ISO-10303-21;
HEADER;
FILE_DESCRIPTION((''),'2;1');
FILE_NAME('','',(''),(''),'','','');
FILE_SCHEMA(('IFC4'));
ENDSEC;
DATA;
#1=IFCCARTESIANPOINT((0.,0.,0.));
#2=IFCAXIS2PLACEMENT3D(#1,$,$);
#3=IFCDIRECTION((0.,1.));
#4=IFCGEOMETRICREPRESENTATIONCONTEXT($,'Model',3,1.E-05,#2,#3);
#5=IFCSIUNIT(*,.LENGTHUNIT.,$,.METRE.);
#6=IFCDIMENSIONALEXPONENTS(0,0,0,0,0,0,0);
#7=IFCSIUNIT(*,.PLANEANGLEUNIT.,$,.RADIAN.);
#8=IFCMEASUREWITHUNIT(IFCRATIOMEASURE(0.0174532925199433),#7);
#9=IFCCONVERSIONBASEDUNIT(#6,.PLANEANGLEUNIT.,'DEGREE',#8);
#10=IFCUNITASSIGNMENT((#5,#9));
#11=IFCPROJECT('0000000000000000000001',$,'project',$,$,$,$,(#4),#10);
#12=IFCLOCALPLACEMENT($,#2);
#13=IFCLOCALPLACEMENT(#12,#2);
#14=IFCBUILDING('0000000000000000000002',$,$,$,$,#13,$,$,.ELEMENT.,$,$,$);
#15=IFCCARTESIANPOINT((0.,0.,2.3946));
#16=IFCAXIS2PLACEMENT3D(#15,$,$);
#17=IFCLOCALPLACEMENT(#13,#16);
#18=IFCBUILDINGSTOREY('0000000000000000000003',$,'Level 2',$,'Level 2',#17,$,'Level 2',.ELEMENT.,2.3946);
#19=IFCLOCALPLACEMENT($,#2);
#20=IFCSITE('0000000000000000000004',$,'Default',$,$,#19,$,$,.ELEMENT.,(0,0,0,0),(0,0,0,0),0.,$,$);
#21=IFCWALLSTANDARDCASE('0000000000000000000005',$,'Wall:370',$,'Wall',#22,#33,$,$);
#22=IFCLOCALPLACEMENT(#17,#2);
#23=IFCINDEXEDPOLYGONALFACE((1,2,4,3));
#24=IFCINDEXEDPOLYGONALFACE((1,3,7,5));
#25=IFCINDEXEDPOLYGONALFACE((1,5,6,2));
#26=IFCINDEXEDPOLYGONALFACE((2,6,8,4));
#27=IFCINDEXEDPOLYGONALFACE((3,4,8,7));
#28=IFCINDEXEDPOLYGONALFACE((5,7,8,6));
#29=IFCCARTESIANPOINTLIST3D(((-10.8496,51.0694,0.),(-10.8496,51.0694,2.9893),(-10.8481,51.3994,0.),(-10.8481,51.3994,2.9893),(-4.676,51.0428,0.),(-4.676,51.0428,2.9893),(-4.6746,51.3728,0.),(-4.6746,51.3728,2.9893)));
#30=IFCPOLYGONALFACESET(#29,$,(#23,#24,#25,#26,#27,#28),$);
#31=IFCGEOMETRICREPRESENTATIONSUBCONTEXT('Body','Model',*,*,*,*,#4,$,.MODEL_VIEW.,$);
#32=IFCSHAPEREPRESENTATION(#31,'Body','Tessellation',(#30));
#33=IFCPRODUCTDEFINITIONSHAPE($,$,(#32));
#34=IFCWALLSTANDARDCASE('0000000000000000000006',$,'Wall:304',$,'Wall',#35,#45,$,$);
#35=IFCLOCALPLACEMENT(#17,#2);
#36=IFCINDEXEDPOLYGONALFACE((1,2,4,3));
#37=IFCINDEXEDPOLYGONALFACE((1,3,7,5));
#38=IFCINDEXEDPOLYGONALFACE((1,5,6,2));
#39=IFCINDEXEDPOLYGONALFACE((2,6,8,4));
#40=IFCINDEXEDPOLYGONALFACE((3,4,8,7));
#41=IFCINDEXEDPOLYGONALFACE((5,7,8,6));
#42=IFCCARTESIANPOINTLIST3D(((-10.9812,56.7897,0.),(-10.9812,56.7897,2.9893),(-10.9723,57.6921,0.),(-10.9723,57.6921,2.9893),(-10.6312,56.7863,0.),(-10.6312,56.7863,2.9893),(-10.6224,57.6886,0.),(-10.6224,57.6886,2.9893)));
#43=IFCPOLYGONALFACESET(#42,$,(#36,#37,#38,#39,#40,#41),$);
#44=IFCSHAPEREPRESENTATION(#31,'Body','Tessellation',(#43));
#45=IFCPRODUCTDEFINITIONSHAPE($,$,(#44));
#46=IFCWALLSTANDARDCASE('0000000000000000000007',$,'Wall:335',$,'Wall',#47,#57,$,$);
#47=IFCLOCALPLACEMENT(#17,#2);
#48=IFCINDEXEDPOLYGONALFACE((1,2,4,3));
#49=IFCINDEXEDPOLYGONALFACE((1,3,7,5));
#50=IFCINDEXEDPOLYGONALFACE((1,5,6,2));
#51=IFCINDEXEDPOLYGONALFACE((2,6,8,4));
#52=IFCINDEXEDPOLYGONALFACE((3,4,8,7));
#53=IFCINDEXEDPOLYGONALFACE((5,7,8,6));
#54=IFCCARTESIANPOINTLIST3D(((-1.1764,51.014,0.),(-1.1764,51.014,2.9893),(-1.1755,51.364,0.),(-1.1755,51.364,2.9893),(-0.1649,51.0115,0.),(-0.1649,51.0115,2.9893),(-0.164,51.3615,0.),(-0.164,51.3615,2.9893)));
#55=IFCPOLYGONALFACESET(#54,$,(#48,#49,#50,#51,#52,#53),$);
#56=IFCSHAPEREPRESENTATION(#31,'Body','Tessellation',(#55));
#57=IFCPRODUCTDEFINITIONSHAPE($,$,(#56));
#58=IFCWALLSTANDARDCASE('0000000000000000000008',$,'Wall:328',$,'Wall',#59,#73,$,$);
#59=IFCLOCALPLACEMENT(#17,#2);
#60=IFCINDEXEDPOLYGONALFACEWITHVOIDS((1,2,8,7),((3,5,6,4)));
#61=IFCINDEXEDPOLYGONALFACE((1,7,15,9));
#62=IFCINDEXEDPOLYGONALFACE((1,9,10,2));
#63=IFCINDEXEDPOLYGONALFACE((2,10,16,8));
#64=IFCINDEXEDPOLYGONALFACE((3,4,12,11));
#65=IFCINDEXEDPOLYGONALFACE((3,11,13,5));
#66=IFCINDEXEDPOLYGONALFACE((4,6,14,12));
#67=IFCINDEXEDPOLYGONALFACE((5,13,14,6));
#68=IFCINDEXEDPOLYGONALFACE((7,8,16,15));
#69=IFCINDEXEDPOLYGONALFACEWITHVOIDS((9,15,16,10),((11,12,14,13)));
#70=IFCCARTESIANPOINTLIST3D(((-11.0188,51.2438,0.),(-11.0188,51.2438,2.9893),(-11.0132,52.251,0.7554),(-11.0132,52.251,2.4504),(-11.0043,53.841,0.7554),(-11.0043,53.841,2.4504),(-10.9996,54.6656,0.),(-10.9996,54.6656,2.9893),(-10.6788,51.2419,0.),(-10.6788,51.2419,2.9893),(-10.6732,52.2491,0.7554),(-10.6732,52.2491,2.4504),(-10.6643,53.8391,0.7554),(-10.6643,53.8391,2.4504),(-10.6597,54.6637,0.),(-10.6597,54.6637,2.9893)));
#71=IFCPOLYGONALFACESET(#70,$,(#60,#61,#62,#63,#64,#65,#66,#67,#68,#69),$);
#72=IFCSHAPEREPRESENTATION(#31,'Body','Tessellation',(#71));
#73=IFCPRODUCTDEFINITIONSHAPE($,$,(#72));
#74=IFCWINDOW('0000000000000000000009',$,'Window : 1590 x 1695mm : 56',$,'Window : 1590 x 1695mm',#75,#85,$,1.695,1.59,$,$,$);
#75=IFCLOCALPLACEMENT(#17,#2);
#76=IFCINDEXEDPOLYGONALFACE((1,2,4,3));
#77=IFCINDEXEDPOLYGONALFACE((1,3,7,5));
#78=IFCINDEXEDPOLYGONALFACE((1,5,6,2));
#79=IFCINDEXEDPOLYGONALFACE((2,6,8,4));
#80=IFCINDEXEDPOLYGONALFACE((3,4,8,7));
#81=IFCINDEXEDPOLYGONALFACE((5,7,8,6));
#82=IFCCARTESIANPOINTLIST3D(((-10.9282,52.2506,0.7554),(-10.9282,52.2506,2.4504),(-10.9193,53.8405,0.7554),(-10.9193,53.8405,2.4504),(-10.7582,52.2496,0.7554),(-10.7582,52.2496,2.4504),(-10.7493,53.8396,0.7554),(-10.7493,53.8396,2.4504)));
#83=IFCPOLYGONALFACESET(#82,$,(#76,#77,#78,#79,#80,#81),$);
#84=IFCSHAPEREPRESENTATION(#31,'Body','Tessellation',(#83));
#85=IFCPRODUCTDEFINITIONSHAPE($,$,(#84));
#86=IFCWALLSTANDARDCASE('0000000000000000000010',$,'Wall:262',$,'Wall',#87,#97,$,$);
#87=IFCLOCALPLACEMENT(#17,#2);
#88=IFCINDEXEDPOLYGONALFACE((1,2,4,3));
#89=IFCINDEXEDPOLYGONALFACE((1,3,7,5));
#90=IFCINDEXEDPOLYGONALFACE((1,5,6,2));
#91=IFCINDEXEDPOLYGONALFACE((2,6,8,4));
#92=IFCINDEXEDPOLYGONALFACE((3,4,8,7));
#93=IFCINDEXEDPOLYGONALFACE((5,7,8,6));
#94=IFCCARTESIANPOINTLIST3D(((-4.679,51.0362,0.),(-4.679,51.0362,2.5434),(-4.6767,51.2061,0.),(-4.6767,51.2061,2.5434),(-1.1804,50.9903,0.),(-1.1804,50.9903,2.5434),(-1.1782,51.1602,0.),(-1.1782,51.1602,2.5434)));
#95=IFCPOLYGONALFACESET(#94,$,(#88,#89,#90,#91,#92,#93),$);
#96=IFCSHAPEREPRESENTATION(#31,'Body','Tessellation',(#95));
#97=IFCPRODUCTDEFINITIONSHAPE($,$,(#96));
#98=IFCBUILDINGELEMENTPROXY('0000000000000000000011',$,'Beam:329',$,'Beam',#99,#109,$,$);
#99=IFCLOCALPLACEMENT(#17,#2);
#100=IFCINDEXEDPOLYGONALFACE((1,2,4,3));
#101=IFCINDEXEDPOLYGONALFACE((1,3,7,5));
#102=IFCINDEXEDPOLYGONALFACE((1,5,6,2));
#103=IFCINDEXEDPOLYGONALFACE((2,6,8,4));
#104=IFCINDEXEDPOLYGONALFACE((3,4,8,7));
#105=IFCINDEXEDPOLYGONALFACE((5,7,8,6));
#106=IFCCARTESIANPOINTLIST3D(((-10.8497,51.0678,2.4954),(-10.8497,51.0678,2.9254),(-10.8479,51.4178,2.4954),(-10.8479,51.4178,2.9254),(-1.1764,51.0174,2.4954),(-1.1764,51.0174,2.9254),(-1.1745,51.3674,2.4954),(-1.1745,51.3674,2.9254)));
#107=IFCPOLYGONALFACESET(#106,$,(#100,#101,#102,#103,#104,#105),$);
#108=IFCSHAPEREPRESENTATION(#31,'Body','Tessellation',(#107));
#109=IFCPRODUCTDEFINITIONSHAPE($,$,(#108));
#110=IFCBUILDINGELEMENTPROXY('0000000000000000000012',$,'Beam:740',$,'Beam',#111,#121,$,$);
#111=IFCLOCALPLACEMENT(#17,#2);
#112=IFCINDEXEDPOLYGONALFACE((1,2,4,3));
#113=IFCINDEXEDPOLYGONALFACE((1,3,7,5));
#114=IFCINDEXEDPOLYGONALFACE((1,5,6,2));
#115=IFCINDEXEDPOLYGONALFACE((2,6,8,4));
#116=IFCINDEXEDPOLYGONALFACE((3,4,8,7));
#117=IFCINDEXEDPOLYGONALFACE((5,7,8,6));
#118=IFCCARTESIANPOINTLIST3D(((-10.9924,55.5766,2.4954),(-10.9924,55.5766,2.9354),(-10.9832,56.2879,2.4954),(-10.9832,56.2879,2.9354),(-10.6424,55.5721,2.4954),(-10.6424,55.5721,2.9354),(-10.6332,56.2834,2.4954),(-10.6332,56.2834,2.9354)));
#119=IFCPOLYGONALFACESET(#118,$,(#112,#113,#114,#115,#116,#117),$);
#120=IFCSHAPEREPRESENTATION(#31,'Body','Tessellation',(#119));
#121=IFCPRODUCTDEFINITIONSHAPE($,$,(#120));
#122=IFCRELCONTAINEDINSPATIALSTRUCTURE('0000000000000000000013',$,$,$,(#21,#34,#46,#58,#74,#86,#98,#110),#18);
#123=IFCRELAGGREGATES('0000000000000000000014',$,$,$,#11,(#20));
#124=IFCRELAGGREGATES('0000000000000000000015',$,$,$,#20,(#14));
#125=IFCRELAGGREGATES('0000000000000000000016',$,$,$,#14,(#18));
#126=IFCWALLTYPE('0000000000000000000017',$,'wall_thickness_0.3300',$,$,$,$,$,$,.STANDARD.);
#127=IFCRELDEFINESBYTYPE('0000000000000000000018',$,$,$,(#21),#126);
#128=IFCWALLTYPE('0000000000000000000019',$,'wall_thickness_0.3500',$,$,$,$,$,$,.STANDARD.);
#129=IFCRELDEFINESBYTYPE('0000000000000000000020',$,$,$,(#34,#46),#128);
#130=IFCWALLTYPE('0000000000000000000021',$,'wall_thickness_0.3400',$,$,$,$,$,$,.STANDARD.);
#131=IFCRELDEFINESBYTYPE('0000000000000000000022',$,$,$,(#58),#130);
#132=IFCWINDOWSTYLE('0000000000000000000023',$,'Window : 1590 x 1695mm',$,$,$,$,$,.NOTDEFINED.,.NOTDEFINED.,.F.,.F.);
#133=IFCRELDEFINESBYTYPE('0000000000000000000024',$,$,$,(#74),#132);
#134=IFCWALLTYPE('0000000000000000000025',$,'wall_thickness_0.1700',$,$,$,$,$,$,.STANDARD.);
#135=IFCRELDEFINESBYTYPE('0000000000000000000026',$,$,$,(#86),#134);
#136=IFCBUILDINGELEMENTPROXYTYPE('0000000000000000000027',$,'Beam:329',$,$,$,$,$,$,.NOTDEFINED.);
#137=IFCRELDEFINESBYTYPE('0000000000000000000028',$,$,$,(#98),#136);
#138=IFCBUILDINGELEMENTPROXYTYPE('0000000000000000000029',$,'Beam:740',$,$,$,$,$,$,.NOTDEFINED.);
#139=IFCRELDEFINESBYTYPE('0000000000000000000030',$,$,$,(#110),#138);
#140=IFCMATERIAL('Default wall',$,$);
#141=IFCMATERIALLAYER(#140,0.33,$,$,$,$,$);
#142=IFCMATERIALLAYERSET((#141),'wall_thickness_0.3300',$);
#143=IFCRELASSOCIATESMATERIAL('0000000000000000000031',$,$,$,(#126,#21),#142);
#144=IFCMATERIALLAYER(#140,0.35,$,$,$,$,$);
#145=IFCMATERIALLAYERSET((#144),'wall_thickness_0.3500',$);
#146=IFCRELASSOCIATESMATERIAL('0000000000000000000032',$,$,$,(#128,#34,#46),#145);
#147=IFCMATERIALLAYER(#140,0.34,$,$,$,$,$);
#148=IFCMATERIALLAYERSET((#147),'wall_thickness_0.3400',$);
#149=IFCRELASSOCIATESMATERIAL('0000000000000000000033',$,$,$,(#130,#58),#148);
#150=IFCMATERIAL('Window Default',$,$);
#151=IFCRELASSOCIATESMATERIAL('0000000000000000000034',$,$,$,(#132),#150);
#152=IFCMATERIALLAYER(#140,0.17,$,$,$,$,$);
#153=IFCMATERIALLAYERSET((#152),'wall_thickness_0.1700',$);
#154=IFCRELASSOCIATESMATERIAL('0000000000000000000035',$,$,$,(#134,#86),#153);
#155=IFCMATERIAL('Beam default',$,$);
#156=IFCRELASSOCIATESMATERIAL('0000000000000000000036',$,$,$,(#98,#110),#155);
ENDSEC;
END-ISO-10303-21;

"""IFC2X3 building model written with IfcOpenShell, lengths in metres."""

from ifc_helpers import new_model, entity, si_unit, converted_unit, direction, frame, frame_2d, origin, origin_2d_with_axis, place, context, subcontext, project, spatial, polyline, rectangle, outline, extrude, source, transform, mapped, material, layer, layer_set, layer_usage, type_object, type_shapes, element, fill, save


model = new_model("IFC2X3")

# Units and contexts
model_context = context("Model", 3, precision=1e-05, world=origin(), true_north=direction((0.0, 1.0)))
body_context = subcontext(model_context, "Body", "Model", "MODEL_VIEW")
ifc_project = project(units=[si_unit("LENGTHUNIT", "METRE"), converted_unit("PLANEANGLEUNIT", "DEGREE", entity("IfcRatioMeasure", 0.0174532925199433), si_unit("PLANEANGLEUNIT", "RADIAN"), dimensions=[0, 0, 0, 0, 0, 0, 0])], contexts=[model_context])

# Site, building, storey
site_placement = place(None, origin())
site = spatial("IfcSite", under=ifc_project, at=site_placement, Name="Default", CompositionType="ELEMENT", RefLatitude=(0, 0, 0, 0), RefLongitude=(0, 0, 0, 0), RefElevation=0.0)
placement_1 = place(None, origin())
building_placement = place(placement_1, origin())
building = spatial("IfcBuilding", under=site, at=building_placement, CompositionType="ELEMENT")
storey_placement = place(building_placement, frame((0.0, 0.0, 2.3946)))
storey = spatial("IfcBuildingStorey", under=building, at=storey_placement, Name="Level 2", ObjectType="Level 2", LongName="Level 2", CompositionType="ELEMENT", Elevation=2.3946)

# Shared definitions
ifc_material_1 = material(Name="Default wall")

# Shared definitions
ifc_material_2 = material(Name="Window Default")

# Walls
ifc_layer_1 = layer(ifc_material_1, 0.33)
ifc_layer_set_1 = layer_set([ifc_layer_1], Name="wall_thickness_0.3300")
ifc_layer_usage_1 = layer_usage(ifc_layer_set_1, "AXIS2", "POSITIVE", -0.165)
wall_type_1 = type_object("IfcWallType", Name="wall_thickness_0.3300", PredefinedType="STANDARD", material=ifc_layer_set_1)
wall_1_placement = place(storey_placement, frame((-10.8489, 51.2344, 0.0), z_axis=(0.0, 0.0, 1.0), x_axis=(0.999991, -0.004316, 0.0)))
element("IfcWallStandardCase", 1, at=wall_1_placement, inside=storey, type_object=wall_type_1, material=ifc_layer_usage_1, Name="Wall:370", ObjectType="Wall", context=body_context, shape_type="SweptSolid", body=[
    extrude(outline(polyline([(6.1736, -0.165), (6.1736, 0.165), (0.0, 0.165), (0.0, -0.165), (6.1736, -0.165)])), origin(), (0.0, 0.0, 1.0), 2.9893),
])
ifc_layer_2 = layer(ifc_material_1, 0.35)
ifc_layer_set_2 = layer_set([ifc_layer_2], Name="wall_thickness_0.3500")
ifc_layer_usage_2 = layer_usage(ifc_layer_set_2, "AXIS2", "POSITIVE", -0.175)
wall_type_2 = type_object("IfcWallType", Name="wall_thickness_0.3500", PredefinedType="STANDARD", material=ifc_layer_set_2)
wall_2_placement = place(storey_placement, frame((-10.7973, 57.6904, 0.0), z_axis=(0.0, 0.0, 1.0), x_axis=(-0.009837, -0.999952, 0.0)))
element("IfcWallStandardCase", 2, at=wall_2_placement, inside=storey, type_object=wall_type_2, material=ifc_layer_usage_2, Name="Wall:304", ObjectType="Wall", context=body_context, shape_type="SweptSolid", body=[
    extrude(outline(polyline([(0.9024, -0.175), (0.9024, 0.175), (0.0, 0.175), (0.0, -0.175), (0.9024, -0.175)])), origin(), (0.0, 0.0, 1.0), 2.9893),
])
wall_3_placement = place(storey_placement, frame((-1.1759, 51.189, 0.0), z_axis=(0.0, 0.0, 1.0), x_axis=(0.999997, -0.002451, 0.0)))
element("IfcWallStandardCase", 3, at=wall_3_placement, inside=storey, type_object=wall_type_2, material=ifc_layer_usage_2, Name="Wall:335", ObjectType="Wall", context=body_context, shape_type="SweptSolid", body=[
    extrude(outline(polyline([(1.0115, -0.175), (1.0115, 0.175), (0.0, 0.175), (0.0, -0.175), (1.0115, -0.175)])), origin(), (0.0, 0.0, 1.0), 2.9893),
])

# Wall, opening, window
ifc_layer_3 = layer(ifc_material_1, 0.34)
ifc_layer_set_3 = layer_set([ifc_layer_3], Name="wall_thickness_0.3400")
ifc_layer_usage_3 = layer_usage(ifc_layer_set_3, "AXIS2", "POSITIVE", -0.17)
wall_type_3 = type_object("IfcWallType", Name="wall_thickness_0.3400", PredefinedType="STANDARD", material=ifc_layer_set_3)
wall_4_placement = place(storey_placement, frame((-10.8297, 54.6647, 0.0), z_axis=(0.0, 0.0, 1.0), x_axis=(-0.005599, -0.999984, 0.0)))
wall_4 = element("IfcWallStandardCase", 4, at=wall_4_placement, inside=storey, type_object=wall_type_3, material=ifc_layer_usage_3, Name="Wall:328", ObjectType="Wall", context=body_context, shape_type="SweptSolid", body=[
    extrude(outline(polyline([(3.4219, -0.17), (3.4219, 0.17), (0.0, 0.17), (0.0, -0.17), (3.4219, -0.17)])), origin(), (0.0, 0.0, 1.0), 2.9893),
])
opening_1_placement = place(wall_4_placement, frame((0.8246, -0.17, 0.7554)))
opening_1 = element("IfcOpeningElement", 5, at=opening_1_placement, cuts=wall_4, ObjectType="Opening", context=body_context, shape_type="SweptSolid", body=[
    extrude(rectangle(XDim=1.59, YDim=1.695, at=frame_2d((0.8475, 0.795), x_axis=(0.0, 1.0))), frame((0.0, 0.0, 0.0), z_axis=(0.0, 1.0, 0.0), x_axis=(0.0, 0.0, 1.0)), (0.0, 0.0, 1.0), 0.34),
])
window_style_1 = type_object("IfcWindowStyle", Name="Window : 1590 x 1695mm", ConstructionType="NOTDEFINED", OperationType="NOTDEFINED", ParameterTakesPrecedence=False, Sizeable=False, material=ifc_material_2)
shared_shape_1 = source(origin(), body_context, "Body", "SweptSolid", [
    extrude(rectangle(XDim=0.17, YDim=1.59, at=origin_2d_with_axis()), frame((0.795, 0.17, 0.0), z_axis=(0.0, 0.0, 1.0), x_axis=(0.0, 1.0, 0.0)), (0.0, 0.0, 1.0), 1.695),
])
type_shapes(window_style_1, [shared_shape_1])
window_1_placement = place(opening_1_placement, origin())
window_1 = element("IfcWindow", 6, at=window_1_placement, inside=storey, type_object=window_style_1, Name="Window : 1590 x 1695mm : 56", ObjectType="Window : 1590 x 1695mm", OverallHeight=1.695, OverallWidth=1.59, context=body_context, shape_type="MappedRepresentation", body=[
    mapped(shared_shape_1, transform((0.0, 0.0, 0.0), scale=1.0)),
])
fill(opening_1, window_1)

# Wall
ifc_layer_4 = layer(ifc_material_1, 0.17)
ifc_layer_set_4 = layer_set([ifc_layer_4], Name="wall_thickness_0.1700")
ifc_layer_usage_4 = layer_usage(ifc_layer_set_4, "AXIS2", "POSITIVE", -0.085)
wall_type_4 = type_object("IfcWallType", Name="wall_thickness_0.1700", PredefinedType="STANDARD", material=ifc_layer_set_4)
wall_5_placement = place(storey_placement, frame((-4.6779, 51.1211, 0.0), z_axis=(0.0, 0.0, 1.0), x_axis=(0.999914, -0.013116, 0.0)))
element("IfcWallStandardCase", 7, at=wall_5_placement, inside=storey, type_object=wall_type_4, material=ifc_layer_usage_4, Name="Wall:262", ObjectType="Wall", context=body_context, shape_type="SweptSolid", body=[
    extrude(outline(polyline([(3.4989, -0.085), (3.4989, 0.085), (0.0, 0.085), (0.0, -0.085), (3.4989, -0.085)])), origin(), (0.0, 0.0, 1.0), 2.5434),
])

# Building element proxies
ifc_material_3 = material(Name="Beam default")
building_element_proxy_type_1 = type_object("IfcBuildingElementProxyType", Name="Beam:329", PredefinedType="NOTDEFINED")
shared_shape_2 = source(origin(), body_context, "Body", "SweptSolid", [
    extrude(outline(polyline([(9.6735, -0.175), (9.6735, 0.175), (0.0, 0.175), (0.0, -0.175), (9.6735, -0.175)])), origin(), (0.0, 0.0, 1.0), 0.43),
])
type_shapes(building_element_proxy_type_1, [shared_shape_2])
placement_2 = place(building_placement, frame((0.0, 0.0, 4.89)))
proxy_1_placement = place(placement_2, frame((-10.8488, 51.2428, 0.0), z_axis=(0.0, 0.0, 1.0), x_axis=(0.999986, -0.005211, 0.0)))
element("IfcBuildingElementProxy", 8, at=proxy_1_placement, inside=storey, type_object=building_element_proxy_type_1, material=ifc_material_3, Name="Beam:329", ObjectType="Beam", context=body_context, shape_type="MappedRepresentation", body=[
    mapped(shared_shape_2, transform((0.0, 0.0, 0.0), scale=1.0)),
])
building_element_proxy_type_2 = type_object("IfcBuildingElementProxyType", Name="Beam:740", PredefinedType="NOTDEFINED")
shared_shape_3 = source(origin(), body_context, "Body", "SweptSolid", [
    extrude(outline(polyline([(0.7113, -0.175), (0.7113, 0.175), (0.0, 0.175), (0.0, -0.175), (0.7113, -0.175)])), origin(), (0.0, 0.0, 1.0), 0.44),
])
type_shapes(building_element_proxy_type_2, [shared_shape_3])
placement_3 = place(building_placement, frame((0.0, 0.0, 4.89)))
proxy_2_placement = place(placement_3, frame((-10.8082, 56.2856, 0.0), z_axis=(0.0, 0.0, 1.0), x_axis=(-0.012954, -0.999916, 0.0)))
element("IfcBuildingElementProxy", 9, at=proxy_2_placement, inside=storey, type_object=building_element_proxy_type_2, material=ifc_material_3, Name="Beam:740", ObjectType="Beam", context=body_context, shape_type="MappedRepresentation", body=[
    mapped(shared_shape_3, transform((0.0, 0.0, 0.0), scale=1.0)),
])

save(model, "model.ifc")
